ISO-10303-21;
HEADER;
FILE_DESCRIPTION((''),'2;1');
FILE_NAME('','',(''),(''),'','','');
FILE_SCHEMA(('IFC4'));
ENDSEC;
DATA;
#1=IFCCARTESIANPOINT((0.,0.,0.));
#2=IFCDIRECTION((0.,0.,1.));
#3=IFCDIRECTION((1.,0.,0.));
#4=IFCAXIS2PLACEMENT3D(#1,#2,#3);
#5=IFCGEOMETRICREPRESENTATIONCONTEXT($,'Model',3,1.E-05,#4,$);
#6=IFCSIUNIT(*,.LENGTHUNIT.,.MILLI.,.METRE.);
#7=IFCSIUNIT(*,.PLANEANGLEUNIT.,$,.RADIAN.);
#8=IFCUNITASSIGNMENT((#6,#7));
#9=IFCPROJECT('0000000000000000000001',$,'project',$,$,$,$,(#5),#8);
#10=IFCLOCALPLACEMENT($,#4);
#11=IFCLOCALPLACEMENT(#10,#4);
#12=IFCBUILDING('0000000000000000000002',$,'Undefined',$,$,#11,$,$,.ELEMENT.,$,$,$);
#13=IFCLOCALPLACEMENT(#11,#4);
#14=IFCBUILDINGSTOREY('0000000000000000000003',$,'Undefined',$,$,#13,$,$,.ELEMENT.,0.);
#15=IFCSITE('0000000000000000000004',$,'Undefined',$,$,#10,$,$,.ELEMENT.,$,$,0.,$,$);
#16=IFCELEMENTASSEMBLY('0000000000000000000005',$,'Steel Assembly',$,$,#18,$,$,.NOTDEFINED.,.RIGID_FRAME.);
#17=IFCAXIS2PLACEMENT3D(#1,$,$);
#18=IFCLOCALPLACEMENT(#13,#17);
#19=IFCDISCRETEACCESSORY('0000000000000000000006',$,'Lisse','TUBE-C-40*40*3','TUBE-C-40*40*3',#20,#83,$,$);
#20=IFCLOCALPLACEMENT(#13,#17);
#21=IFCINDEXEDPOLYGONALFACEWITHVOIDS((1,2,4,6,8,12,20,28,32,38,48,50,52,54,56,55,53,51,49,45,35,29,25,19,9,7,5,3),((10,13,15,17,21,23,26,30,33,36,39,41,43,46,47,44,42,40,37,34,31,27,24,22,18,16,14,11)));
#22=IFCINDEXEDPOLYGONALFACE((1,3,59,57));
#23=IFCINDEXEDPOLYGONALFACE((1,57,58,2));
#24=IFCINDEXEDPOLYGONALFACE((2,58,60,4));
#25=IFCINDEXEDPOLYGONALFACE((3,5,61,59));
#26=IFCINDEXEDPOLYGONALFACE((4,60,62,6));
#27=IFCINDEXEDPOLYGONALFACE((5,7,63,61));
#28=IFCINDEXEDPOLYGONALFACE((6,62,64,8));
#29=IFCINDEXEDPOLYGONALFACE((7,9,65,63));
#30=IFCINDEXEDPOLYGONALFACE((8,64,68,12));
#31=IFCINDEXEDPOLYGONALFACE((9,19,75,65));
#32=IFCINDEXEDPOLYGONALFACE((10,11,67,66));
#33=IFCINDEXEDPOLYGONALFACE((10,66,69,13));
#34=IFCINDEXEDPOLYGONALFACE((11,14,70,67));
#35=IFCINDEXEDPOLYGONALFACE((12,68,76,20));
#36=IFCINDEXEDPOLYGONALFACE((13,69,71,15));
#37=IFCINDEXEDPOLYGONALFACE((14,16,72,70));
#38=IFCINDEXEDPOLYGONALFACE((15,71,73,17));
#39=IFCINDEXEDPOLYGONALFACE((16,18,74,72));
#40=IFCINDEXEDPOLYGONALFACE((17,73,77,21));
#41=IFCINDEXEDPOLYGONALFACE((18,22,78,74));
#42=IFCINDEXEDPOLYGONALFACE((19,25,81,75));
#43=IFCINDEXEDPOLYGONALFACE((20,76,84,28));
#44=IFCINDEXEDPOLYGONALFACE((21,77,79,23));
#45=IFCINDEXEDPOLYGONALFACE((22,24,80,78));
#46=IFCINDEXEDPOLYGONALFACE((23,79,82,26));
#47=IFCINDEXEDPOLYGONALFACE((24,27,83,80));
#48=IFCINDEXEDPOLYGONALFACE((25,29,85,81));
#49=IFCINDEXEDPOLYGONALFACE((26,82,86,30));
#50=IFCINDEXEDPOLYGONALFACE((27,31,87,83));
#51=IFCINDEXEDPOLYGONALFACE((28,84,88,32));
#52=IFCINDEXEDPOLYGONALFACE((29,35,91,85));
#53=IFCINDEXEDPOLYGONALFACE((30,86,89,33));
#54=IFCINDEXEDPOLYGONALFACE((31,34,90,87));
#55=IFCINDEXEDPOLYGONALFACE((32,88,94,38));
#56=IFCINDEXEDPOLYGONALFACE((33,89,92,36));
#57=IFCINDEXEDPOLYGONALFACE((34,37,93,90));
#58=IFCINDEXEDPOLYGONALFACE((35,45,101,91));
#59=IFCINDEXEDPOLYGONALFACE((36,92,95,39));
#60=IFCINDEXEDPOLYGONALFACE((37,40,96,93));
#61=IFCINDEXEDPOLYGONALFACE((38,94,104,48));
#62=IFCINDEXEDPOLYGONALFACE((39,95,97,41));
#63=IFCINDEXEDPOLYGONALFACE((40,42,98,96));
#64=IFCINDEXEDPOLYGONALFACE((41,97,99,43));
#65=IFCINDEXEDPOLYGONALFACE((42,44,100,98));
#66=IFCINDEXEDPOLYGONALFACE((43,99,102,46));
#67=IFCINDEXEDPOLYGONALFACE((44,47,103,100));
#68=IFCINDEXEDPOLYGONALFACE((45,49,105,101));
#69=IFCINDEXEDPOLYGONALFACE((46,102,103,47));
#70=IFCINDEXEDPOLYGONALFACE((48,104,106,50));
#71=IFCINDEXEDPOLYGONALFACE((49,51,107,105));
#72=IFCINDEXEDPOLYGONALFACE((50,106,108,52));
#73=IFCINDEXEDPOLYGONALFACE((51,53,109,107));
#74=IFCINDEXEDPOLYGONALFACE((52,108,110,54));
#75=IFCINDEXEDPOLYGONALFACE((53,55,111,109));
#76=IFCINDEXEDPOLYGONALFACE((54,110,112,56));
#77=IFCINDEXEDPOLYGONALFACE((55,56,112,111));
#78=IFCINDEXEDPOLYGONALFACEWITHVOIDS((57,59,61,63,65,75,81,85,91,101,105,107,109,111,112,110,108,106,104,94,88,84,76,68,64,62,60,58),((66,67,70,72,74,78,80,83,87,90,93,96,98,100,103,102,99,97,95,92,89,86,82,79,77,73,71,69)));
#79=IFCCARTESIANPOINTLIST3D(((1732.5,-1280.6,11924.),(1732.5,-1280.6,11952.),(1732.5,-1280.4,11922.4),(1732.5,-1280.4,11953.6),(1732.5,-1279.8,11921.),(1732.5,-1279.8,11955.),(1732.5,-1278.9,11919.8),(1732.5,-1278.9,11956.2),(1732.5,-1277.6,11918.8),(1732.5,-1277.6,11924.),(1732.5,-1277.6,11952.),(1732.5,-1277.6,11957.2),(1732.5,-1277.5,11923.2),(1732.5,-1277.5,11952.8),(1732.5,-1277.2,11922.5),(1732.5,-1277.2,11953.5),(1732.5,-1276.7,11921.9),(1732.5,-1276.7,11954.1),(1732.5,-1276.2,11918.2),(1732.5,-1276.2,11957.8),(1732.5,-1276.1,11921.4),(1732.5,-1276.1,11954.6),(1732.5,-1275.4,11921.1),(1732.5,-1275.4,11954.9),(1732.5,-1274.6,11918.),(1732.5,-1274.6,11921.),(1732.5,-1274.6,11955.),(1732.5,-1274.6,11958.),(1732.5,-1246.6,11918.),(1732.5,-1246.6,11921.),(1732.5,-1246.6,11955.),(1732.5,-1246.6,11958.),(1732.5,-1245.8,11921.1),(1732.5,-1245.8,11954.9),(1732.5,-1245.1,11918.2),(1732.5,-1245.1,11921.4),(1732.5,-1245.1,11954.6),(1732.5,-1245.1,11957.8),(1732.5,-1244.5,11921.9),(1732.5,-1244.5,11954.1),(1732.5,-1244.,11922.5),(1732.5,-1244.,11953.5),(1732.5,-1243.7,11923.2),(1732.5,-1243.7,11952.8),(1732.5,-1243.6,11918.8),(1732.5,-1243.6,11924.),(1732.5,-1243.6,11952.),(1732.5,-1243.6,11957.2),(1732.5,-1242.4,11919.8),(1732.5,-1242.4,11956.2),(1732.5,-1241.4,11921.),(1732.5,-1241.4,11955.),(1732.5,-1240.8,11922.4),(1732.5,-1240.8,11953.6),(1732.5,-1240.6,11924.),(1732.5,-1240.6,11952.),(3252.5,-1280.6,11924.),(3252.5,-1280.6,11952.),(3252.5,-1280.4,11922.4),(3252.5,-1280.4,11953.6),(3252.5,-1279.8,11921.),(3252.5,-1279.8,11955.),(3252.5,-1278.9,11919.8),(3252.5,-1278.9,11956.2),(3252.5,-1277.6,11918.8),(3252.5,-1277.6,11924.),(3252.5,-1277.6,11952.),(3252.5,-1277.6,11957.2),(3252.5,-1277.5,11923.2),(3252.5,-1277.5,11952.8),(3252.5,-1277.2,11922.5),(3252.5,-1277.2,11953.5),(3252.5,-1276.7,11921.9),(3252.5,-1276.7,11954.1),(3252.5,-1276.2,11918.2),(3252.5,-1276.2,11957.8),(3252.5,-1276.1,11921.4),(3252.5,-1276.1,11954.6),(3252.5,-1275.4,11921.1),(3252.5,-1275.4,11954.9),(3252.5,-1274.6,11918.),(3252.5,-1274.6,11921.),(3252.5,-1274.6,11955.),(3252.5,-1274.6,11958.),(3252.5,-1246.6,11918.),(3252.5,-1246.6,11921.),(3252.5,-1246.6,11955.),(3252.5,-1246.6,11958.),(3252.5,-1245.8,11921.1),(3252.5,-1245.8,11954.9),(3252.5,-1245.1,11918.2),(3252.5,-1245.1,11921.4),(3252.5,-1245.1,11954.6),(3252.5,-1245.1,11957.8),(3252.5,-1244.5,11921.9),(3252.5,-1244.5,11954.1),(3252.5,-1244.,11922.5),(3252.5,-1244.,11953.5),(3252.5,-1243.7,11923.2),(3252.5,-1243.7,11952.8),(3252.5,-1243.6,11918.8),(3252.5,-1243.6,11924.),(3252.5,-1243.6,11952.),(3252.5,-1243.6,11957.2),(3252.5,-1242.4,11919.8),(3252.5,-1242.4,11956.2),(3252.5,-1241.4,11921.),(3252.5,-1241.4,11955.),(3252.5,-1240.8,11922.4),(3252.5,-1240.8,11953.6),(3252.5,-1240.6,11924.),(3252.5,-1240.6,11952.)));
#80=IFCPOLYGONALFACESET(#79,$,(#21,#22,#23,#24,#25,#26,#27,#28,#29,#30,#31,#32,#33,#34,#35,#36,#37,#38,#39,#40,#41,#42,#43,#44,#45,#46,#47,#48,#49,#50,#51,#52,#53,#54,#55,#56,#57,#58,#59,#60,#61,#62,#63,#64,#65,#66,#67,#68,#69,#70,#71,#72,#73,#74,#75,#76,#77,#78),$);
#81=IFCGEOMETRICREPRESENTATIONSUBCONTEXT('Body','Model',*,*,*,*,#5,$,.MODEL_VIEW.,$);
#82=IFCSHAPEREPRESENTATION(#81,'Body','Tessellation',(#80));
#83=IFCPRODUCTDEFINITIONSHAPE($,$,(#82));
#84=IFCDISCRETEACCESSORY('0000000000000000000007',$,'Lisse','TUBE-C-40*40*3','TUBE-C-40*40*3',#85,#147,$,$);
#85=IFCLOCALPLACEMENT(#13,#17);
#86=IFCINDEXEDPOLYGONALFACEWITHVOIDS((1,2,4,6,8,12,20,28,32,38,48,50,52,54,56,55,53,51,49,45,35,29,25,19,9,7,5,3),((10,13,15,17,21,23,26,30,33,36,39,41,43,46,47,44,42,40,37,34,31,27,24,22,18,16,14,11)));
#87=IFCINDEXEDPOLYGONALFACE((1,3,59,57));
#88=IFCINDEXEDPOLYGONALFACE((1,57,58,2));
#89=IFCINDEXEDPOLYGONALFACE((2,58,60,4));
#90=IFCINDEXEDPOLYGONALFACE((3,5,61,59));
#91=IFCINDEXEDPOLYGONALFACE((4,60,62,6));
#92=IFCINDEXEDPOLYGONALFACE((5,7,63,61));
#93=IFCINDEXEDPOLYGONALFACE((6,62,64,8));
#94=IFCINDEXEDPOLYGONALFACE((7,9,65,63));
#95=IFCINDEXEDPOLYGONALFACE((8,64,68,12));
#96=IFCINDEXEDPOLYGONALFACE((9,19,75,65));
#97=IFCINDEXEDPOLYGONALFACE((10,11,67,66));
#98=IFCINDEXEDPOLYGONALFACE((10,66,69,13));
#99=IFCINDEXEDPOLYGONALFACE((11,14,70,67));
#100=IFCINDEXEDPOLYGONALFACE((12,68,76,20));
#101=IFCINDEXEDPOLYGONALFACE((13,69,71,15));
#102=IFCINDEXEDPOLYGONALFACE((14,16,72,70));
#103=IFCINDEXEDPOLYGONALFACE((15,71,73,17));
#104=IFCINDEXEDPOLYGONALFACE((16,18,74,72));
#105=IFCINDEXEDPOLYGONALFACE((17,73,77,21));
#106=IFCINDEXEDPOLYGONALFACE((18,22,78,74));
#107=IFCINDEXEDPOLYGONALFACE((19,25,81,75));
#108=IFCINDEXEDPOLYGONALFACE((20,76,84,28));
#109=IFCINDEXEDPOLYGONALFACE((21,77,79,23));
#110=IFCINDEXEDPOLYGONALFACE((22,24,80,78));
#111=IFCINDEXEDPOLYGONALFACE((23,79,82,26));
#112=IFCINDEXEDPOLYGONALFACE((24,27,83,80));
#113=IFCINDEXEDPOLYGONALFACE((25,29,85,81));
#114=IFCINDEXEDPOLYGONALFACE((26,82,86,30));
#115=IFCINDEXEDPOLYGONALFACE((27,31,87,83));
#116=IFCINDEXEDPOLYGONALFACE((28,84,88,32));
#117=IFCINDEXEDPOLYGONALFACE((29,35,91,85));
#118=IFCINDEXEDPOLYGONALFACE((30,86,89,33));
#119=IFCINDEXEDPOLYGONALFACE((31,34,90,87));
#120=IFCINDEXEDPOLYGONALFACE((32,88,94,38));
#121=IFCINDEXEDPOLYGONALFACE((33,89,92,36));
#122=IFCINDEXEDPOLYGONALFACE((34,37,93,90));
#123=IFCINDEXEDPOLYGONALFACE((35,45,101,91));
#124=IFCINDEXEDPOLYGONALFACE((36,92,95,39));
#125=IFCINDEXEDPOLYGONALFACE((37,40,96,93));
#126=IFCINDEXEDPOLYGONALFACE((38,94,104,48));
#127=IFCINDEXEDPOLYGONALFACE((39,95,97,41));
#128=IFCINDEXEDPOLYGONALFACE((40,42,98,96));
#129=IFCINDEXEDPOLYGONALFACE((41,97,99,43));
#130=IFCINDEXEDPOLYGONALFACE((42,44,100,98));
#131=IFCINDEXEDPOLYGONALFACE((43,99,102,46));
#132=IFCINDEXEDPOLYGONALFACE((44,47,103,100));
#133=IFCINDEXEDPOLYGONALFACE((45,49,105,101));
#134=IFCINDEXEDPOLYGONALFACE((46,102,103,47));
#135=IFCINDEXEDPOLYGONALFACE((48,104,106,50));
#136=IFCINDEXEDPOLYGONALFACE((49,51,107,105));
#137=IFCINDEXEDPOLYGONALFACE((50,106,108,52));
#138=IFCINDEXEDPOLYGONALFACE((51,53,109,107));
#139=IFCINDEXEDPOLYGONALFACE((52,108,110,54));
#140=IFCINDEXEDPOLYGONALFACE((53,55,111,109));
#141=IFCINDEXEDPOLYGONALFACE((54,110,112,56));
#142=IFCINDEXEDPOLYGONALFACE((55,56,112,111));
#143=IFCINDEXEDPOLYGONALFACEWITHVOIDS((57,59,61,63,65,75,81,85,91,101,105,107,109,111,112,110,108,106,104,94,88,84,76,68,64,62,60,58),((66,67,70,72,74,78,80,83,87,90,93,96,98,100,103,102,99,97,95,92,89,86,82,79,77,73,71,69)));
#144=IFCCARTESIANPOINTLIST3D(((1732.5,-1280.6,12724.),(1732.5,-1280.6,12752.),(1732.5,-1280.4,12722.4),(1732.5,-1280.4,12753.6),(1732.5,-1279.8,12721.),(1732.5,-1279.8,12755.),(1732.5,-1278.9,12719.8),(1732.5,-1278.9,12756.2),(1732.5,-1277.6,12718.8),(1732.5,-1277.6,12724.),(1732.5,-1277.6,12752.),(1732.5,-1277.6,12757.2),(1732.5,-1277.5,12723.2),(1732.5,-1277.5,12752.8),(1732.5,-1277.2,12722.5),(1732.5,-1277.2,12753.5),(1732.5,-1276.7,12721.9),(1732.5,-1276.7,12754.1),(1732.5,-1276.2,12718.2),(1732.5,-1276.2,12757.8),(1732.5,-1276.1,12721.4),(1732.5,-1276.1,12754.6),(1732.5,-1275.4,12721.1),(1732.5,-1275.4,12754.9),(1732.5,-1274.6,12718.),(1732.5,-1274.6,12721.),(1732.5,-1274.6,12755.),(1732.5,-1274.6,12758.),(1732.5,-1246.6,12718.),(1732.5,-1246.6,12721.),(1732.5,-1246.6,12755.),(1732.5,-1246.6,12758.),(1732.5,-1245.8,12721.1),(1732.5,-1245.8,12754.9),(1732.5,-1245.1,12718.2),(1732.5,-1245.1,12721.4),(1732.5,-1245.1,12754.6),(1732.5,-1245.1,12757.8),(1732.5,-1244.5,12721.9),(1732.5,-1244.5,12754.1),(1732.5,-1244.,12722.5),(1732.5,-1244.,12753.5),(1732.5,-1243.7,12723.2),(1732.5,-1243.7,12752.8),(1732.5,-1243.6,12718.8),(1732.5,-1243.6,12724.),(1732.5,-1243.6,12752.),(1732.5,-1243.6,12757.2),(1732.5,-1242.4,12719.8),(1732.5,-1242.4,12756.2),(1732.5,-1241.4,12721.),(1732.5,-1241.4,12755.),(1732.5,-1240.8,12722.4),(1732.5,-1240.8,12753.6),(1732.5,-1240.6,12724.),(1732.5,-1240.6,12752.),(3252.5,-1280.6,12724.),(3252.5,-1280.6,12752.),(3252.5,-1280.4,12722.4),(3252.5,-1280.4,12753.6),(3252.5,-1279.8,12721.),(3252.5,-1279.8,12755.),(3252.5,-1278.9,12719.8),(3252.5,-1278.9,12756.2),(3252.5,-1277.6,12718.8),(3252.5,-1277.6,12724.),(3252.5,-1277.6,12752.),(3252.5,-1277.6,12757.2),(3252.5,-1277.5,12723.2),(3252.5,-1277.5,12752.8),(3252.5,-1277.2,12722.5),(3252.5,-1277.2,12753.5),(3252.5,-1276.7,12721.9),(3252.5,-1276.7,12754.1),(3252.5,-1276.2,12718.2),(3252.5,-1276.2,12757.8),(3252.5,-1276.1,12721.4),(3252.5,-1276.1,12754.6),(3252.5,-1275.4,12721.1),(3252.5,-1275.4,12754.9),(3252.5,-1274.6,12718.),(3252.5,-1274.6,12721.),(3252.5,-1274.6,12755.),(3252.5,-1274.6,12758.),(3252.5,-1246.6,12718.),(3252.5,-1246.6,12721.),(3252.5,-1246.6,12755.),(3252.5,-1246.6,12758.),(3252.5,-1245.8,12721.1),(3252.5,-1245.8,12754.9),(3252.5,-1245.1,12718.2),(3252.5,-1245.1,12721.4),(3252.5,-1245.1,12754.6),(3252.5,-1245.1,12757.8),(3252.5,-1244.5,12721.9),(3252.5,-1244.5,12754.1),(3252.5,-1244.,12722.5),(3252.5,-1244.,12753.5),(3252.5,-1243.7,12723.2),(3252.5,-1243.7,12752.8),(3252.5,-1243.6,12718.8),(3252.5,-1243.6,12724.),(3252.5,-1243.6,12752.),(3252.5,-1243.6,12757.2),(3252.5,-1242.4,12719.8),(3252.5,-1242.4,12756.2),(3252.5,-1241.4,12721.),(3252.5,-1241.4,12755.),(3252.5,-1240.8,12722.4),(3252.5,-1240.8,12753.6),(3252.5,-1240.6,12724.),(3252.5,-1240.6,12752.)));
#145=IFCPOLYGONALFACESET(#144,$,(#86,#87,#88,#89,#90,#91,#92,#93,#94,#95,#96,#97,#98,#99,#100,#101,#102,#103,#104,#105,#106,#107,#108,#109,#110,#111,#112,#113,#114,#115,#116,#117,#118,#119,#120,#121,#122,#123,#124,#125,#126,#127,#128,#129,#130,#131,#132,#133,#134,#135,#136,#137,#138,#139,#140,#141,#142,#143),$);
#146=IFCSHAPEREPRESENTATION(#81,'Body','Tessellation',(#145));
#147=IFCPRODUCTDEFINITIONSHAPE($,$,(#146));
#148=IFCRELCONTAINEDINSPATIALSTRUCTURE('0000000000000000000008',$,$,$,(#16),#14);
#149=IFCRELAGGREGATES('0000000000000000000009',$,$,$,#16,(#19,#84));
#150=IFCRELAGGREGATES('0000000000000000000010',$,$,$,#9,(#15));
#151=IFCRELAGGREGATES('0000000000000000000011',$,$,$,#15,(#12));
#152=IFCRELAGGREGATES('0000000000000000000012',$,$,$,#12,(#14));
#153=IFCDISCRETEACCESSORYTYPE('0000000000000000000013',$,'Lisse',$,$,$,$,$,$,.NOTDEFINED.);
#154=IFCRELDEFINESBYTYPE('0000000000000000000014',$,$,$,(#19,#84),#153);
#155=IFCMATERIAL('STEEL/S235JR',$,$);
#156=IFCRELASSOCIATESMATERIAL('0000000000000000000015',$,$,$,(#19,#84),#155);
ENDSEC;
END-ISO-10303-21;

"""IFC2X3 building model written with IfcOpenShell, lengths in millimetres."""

from ifc_helpers import new_model, si_unit, frame, origin_with_axes, origin_2d_with_axis, place, context, subcontext, project, spatial, hollow_rectangle, extrude, material, type_object, element, aggregate, save


model = new_model("IFC2X3")

# Units and contexts
model_context = context("Model", 3, precision=1e-05, world=origin_with_axes())
body_context = subcontext(model_context, "Body", "Model", "MODEL_VIEW")
ifc_project = project(units=[si_unit("LENGTHUNIT", "METRE", prefix="MILLI"), si_unit("PLANEANGLEUNIT", "RADIAN")], contexts=[model_context])

# Site, building, storey
site_placement = place(None, origin_with_axes())
site = spatial("IfcSite", under=ifc_project, at=site_placement, Name="Undefined", CompositionType="ELEMENT", RefElevation=0.0)
building_placement = place(site_placement, origin_with_axes())
building = spatial("IfcBuilding", under=site, at=building_placement, Name="Undefined", CompositionType="ELEMENT")
storey_placement = place(building_placement, origin_with_axes())
storey = spatial("IfcBuildingStorey", under=building, at=storey_placement, Name="Undefined", CompositionType="ELEMENT", Elevation=0.0)

# Shared definitions
ifc_material_1 = material(Name="STEEL/S235JR")

# Element assembly
assembly_1_placement = place(storey_placement, origin_with_axes())
assembly_1 = element("IfcElementAssembly", 1, at=assembly_1_placement, inside=storey, Name="Steel Assembly", AssemblyPlace="NOTDEFINED", PredefinedType="RIGID_FRAME")

# Discrete accessories
discrete_accessory_type_1 = type_object("IfcDiscreteAccessoryType", Name="Lisse")
discrete_accessory_1_placement = place(assembly_1_placement, frame((3252.5, -1260.6, 11938.0), z_axis=(0.0, 1.0, 0.0), x_axis=(-1.0, 0.0, 0.0)))
discrete_accessory_1 = element("IfcDiscreteAccessory", 2, at=discrete_accessory_1_placement, type_object=discrete_accessory_type_1, material=ifc_material_1, Name="Lisse", Description="TUBE-C-40*40*3", ObjectType="TUBE-C-40*40*3", context=body_context, shape_type="SweptSolid", body=[
    extrude(hollow_rectangle(XDim=40.0, YDim=40.0, WallThickness=3.0, InnerFilletRadius=3.0, OuterFilletRadius=6.0, at=origin_2d_with_axis()), frame((1520.0, 0.0, 0.0), z_axis=(-1.0, 0.0, 0.0), x_axis=(0.0, -1.0, 0.0)), (0.0, 0.0, 1.0), 1520.0),
])
discrete_accessory_2_placement = place(assembly_1_placement, frame((3252.5, -1260.6, 12738.0), z_axis=(0.0, 1.0, 0.0), x_axis=(-1.0, 0.0, 0.0)))
discrete_accessory_2 = element("IfcDiscreteAccessory", 3, at=discrete_accessory_2_placement, type_object=discrete_accessory_type_1, material=ifc_material_1, Name="Lisse", Description="TUBE-C-40*40*3", ObjectType="TUBE-C-40*40*3", context=body_context, shape_type="SweptSolid", body=[
    extrude(hollow_rectangle(XDim=40.0, YDim=40.0, WallThickness=3.0, InnerFilletRadius=3.0, OuterFilletRadius=6.0, at=origin_2d_with_axis()), frame((1520.0, 0.0, 0.0), z_axis=(-1.0, 0.0, 0.0), x_axis=(0.0, -1.0, 0.0)), (0.0, 0.0, 1.0), 1520.0),
])
aggregate(assembly_1, [discrete_accessory_1, discrete_accessory_2])

save(model, "model.ifc")
